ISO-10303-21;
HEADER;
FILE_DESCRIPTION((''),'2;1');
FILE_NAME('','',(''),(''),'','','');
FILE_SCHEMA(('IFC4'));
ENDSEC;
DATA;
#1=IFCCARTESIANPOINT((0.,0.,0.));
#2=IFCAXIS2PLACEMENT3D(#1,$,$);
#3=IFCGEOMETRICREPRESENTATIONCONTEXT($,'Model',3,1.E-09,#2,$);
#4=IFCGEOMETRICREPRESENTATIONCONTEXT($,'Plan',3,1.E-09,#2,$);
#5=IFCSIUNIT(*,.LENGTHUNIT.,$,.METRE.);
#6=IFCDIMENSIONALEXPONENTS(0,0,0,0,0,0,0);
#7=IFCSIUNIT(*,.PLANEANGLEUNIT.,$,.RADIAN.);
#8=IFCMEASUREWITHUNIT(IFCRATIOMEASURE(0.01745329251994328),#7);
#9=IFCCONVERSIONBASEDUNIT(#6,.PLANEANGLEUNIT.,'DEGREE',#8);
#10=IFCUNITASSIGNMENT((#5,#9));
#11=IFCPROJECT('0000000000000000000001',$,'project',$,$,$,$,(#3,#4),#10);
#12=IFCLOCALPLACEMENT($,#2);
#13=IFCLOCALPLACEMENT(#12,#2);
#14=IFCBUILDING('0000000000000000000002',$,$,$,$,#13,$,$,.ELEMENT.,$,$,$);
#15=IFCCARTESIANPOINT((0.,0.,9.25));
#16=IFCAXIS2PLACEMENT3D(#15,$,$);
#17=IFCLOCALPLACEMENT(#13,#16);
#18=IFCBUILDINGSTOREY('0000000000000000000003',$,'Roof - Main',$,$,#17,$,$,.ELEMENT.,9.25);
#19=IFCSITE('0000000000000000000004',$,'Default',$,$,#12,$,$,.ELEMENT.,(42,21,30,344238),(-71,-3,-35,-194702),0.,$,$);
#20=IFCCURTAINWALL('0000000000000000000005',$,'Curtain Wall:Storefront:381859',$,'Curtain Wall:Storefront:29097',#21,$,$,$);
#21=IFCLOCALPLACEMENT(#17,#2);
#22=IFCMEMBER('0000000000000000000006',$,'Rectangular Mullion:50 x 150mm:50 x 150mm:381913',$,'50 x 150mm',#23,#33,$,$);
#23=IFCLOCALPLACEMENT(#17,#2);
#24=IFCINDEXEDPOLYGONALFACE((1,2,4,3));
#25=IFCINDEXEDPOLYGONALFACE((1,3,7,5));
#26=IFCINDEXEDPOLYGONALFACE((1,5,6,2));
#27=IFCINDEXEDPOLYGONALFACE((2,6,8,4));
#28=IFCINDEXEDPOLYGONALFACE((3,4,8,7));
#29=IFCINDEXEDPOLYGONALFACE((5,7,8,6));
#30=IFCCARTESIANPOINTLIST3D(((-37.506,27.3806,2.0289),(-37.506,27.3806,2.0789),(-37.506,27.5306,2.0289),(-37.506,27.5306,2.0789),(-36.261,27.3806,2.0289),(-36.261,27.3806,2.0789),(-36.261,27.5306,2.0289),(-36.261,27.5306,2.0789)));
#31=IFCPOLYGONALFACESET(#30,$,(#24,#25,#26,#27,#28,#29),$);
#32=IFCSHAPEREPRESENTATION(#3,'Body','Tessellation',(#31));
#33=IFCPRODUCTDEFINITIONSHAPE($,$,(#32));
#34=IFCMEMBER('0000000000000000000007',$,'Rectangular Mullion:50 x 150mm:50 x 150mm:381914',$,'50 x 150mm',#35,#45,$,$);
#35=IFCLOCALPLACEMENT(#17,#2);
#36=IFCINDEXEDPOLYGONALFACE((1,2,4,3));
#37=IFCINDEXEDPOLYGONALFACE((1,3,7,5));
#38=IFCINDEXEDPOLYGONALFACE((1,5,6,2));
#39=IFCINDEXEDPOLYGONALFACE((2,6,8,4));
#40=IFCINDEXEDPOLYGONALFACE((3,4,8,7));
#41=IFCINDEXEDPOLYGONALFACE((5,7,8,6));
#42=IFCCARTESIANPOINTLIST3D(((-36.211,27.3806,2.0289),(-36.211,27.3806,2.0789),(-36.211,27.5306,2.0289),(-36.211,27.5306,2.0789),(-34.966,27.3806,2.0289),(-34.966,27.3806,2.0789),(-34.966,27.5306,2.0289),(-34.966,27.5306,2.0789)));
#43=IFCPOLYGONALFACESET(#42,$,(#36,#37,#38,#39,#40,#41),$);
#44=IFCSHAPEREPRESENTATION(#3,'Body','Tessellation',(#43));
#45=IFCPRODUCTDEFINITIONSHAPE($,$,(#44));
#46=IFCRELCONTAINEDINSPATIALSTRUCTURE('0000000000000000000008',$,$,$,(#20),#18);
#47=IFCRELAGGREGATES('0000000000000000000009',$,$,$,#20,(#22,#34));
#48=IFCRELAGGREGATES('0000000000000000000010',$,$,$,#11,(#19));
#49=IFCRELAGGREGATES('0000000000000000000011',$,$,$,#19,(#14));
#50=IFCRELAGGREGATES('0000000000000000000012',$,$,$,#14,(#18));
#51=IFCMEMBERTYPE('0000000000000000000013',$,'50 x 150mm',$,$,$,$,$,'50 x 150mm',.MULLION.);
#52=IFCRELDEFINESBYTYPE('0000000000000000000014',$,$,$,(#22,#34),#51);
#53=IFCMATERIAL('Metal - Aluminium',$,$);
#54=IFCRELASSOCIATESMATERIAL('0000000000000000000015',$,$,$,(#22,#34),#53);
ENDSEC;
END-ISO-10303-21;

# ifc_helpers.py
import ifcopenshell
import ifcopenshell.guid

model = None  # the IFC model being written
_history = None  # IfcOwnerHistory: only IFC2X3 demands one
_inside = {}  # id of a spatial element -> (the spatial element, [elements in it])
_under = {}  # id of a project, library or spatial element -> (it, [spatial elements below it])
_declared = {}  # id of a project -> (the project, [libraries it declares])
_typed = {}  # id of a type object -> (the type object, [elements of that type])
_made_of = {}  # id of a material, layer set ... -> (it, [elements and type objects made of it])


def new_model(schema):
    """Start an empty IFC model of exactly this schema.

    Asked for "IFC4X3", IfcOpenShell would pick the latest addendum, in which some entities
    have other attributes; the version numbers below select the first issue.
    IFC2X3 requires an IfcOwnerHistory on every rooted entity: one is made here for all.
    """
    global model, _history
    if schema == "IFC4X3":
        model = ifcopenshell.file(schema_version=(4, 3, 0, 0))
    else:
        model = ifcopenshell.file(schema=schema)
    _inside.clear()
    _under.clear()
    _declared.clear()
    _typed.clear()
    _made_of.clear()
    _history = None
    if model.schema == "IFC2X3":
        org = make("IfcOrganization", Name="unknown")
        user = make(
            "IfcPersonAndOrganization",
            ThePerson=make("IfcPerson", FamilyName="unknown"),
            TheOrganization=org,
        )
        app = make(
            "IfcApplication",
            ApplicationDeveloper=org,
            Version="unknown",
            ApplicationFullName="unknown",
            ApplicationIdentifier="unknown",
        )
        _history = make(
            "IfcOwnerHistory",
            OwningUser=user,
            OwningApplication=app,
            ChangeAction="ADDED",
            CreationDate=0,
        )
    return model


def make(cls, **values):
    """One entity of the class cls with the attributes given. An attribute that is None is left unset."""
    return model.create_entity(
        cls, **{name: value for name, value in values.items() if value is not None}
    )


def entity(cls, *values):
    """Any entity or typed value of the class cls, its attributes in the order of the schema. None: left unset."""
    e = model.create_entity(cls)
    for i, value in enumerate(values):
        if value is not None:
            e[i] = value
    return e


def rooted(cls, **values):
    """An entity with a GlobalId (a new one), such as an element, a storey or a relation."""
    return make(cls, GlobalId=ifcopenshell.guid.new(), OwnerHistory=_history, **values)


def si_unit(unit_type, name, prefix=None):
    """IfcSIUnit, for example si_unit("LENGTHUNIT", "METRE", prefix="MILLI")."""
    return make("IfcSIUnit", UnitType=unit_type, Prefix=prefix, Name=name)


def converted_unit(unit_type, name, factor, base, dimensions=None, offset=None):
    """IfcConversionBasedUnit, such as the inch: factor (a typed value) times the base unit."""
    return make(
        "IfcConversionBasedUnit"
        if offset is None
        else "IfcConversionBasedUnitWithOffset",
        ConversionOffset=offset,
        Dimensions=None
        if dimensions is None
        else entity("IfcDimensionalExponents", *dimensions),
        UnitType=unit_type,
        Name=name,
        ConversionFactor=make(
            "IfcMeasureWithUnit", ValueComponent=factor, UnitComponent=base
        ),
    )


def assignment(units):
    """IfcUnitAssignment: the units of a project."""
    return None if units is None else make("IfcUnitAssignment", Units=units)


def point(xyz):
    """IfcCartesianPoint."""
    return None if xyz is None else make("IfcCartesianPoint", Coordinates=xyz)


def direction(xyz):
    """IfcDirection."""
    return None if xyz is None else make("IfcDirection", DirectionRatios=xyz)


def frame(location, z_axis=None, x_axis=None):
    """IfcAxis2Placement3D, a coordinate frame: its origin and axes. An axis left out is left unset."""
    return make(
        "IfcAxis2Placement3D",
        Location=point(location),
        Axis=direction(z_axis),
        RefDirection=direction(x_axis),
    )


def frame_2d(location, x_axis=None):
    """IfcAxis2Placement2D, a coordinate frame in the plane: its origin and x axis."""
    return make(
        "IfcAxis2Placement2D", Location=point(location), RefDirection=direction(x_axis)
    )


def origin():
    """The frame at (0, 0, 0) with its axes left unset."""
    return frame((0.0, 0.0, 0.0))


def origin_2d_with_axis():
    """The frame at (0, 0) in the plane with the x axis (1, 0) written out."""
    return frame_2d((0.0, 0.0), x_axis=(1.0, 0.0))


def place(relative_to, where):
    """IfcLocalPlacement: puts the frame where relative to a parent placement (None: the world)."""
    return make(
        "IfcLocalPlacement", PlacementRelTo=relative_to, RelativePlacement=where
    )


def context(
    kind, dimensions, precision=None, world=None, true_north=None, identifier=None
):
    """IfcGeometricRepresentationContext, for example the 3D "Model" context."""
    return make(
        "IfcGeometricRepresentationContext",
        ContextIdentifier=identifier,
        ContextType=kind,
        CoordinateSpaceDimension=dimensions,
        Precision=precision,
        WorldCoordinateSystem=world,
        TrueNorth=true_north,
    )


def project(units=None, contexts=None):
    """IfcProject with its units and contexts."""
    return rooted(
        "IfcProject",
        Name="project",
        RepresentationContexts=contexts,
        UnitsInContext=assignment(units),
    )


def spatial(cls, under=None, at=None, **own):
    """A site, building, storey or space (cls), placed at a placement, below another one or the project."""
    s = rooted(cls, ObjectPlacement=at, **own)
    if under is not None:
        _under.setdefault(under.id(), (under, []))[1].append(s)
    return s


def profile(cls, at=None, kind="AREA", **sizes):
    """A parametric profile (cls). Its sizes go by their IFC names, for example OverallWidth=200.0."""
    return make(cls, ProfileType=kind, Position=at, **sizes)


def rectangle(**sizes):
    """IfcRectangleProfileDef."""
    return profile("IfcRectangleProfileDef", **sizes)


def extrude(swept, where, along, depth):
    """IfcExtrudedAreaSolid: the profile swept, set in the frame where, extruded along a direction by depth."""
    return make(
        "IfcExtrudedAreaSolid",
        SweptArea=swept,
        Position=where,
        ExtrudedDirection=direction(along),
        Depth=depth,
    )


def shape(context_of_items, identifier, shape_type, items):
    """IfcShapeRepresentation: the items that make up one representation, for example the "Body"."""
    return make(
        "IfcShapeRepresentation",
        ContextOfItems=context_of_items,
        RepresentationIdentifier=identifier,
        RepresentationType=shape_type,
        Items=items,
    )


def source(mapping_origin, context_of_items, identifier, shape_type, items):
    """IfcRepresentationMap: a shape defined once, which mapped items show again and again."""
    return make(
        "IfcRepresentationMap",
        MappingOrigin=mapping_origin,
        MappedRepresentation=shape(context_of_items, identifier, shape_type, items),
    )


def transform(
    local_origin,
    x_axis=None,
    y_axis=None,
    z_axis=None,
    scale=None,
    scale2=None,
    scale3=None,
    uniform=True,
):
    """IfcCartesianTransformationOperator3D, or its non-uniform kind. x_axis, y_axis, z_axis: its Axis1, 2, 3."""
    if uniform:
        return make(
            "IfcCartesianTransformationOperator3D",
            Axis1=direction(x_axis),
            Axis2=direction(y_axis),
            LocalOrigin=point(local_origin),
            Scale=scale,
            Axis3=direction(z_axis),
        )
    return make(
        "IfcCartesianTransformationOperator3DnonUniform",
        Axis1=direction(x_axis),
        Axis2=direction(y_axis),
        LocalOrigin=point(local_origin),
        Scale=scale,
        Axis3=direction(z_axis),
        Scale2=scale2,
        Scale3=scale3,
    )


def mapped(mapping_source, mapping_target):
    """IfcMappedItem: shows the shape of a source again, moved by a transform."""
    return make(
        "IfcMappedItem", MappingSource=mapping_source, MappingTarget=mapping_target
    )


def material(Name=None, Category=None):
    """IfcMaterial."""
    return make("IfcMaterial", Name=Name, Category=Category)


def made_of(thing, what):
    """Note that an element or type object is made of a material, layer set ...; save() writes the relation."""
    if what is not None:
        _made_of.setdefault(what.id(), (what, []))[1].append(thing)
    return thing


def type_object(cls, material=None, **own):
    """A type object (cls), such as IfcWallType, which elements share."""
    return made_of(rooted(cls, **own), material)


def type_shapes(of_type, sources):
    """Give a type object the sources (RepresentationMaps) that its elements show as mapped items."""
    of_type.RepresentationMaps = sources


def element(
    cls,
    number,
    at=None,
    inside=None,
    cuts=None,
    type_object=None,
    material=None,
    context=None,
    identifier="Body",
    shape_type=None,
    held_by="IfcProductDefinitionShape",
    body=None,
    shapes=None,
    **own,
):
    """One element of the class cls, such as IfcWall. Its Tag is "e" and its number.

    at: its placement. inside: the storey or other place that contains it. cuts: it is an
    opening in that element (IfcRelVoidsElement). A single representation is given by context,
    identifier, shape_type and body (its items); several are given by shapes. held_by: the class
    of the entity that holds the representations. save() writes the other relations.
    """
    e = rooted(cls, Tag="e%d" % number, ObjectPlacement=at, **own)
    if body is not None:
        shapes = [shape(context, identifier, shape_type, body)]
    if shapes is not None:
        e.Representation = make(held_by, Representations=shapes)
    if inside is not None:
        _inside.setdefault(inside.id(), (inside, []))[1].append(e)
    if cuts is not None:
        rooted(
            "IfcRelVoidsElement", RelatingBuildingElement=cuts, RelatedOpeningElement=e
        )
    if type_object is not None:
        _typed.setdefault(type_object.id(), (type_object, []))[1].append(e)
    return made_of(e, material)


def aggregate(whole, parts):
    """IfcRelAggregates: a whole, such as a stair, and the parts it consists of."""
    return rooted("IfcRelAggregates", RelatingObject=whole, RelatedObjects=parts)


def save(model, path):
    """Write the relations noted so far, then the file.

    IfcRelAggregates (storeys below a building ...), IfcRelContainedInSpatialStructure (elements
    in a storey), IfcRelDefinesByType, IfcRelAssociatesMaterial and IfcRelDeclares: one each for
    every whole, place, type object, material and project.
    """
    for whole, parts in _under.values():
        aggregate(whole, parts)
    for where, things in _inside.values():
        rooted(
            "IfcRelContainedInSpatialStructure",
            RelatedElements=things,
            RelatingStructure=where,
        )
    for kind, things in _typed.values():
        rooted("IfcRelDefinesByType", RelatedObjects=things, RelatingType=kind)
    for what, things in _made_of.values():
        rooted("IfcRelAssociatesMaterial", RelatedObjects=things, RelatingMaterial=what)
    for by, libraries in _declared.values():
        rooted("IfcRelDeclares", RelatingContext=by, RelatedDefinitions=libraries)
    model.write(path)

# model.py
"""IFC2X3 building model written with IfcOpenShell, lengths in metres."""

from ifc_helpers import new_model, entity, si_unit, converted_unit, frame, origin, origin_2d_with_axis, place, context, project, spatial, rectangle, extrude, source, transform, mapped, material, type_object, type_shapes, element, aggregate, save


model = new_model("IFC2X3")

# Units and contexts
model_context = context("Model", 3, precision=1e-09, world=origin())
plan_context = context("Plan", 3, precision=1e-09, world=origin())
ifc_project = project(units=[si_unit("LENGTHUNIT", "METRE"), converted_unit("PLANEANGLEUNIT", "DEGREE", entity("IfcRatioMeasure", 0.01745329251994328), si_unit("PLANEANGLEUNIT", "RADIAN"), dimensions=[0, 0, 0, 0, 0, 0, 0])], contexts=[model_context, plan_context])

# Site, building, storey
site_placement = place(None, origin())
site = spatial("IfcSite", under=ifc_project, at=site_placement, Name="Default", CompositionType="ELEMENT", RefLatitude=(42, 21, 30, 344238), RefLongitude=(-71, -3, -35, -194702), RefElevation=0.0)
building_placement = place(site_placement, origin())
building = spatial("IfcBuilding", under=site, at=building_placement, CompositionType="ELEMENT")
storey_placement = place(building_placement, frame((0.0, 0.0, 9.25)))
storey = spatial("IfcBuildingStorey", under=building, at=storey_placement, Name="Roof - Main", CompositionType="ELEMENT", Elevation=9.25)

# Curtain wall, members
curtain_wall_placement = place(storey_placement, origin())
curtain_wall = element("IfcCurtainWall", 1, at=curtain_wall_placement, inside=storey, Name="Curtain Wall:Storefront:381859", ObjectType="Curtain Wall:Storefront:29097")
ifc_material_1 = material(Name="Metal - Aluminium")
member_type_1 = type_object("IfcMemberType", Name="50 x 150mm", ElementType="50 x 150mm", PredefinedType="MULLION")
shared_shape_1 = source(origin(), model_context, "Body", "SweptSolid", [
    extrude(rectangle(XDim=0.05, YDim=0.15, at=origin_2d_with_axis()), frame((0.0, 0.0, -1.245), z_axis=(0.0, 0.0, 1.0), x_axis=(-1.0, 0.0, 0.0)), (0.0, 0.0, 1.0), 1.245),
])
type_shapes(member_type_1, [shared_shape_1])
member_1_placement = place(storey_placement, frame((-36.261, 27.4556, 2.0539), z_axis=(1.0, 0.0, 0.0), x_axis=(0.0, 0.0, 1.0)))
member_1 = element("IfcMember", 2, at=member_1_placement, type_object=member_type_1, material=ifc_material_1, Name="Rectangular Mullion:50 x 150mm:50 x 150mm:381913", ObjectType="50 x 150mm", context=model_context, shape_type="MappedRepresentation", body=[
    mapped(shared_shape_1, transform((0.0, 0.0, 0.0), scale=1.0)),
])
member_2_placement = place(storey_placement, frame((-34.966, 27.4556, 2.0539), z_axis=(1.0, 0.0, 0.0), x_axis=(0.0, 0.0, 1.0)))
member_2 = element("IfcMember", 3, at=member_2_placement, type_object=member_type_1, material=ifc_material_1, Name="Rectangular Mullion:50 x 150mm:50 x 150mm:381914", ObjectType="50 x 150mm", context=model_context, shape_type="MappedRepresentation", body=[
    mapped(shared_shape_1, transform((0.0, 0.0, 0.0), scale=1.0)),
])
aggregate(curtain_wall, [member_1, member_2])

save(model, "model.ifc")
